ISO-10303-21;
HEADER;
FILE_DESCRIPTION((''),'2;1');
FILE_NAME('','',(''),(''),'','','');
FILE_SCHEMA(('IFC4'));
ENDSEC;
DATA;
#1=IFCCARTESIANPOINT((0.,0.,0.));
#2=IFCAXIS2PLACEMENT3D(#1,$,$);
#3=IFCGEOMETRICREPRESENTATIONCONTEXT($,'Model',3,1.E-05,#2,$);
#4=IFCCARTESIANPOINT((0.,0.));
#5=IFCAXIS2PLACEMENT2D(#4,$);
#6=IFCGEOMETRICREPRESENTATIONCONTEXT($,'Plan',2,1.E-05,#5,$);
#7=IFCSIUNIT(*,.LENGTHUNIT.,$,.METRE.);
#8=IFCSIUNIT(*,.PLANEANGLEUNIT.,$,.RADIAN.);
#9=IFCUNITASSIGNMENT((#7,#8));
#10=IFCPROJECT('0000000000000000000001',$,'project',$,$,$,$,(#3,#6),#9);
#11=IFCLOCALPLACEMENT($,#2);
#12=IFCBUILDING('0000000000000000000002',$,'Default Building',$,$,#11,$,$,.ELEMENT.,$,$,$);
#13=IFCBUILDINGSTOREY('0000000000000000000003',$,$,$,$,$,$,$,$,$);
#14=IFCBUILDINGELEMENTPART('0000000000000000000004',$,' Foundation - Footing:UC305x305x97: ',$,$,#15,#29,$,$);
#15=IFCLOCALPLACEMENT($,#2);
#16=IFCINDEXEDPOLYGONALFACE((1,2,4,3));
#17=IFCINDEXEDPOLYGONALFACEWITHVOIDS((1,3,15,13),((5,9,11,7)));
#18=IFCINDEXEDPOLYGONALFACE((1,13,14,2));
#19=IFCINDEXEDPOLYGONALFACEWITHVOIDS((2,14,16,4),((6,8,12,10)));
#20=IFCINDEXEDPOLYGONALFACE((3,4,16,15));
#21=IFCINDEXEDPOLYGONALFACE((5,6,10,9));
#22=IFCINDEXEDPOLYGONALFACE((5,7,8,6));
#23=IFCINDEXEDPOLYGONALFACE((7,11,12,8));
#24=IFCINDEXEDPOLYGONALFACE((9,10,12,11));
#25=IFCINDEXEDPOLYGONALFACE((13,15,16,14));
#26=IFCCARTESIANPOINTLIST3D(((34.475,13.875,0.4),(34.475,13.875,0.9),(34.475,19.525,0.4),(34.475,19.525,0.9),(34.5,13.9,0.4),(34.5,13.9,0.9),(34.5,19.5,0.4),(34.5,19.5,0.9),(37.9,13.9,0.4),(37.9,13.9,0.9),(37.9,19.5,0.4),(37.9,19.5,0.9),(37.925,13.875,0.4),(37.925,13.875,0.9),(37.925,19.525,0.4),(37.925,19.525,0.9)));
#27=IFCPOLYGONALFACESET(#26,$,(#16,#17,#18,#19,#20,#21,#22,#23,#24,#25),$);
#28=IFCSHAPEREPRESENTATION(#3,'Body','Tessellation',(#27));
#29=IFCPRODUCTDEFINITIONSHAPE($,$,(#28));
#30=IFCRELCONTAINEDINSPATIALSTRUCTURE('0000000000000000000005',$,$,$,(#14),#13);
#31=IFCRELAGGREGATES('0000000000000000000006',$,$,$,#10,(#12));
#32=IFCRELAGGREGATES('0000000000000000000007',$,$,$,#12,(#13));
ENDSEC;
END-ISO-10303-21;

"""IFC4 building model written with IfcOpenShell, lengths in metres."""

from ifc_helpers import new_model, si_unit, origin, origin_2d, place, context, project, spatial, polyline, outline, extrude, element, save


model = new_model("IFC4")

# Units and contexts
model_context = context("Model", 3, precision=1e-05, world=origin())
plan_context = context("Plan", 2, precision=1e-05, world=origin_2d())
ifc_project = project(units=[si_unit("LENGTHUNIT", "METRE"), si_unit("PLANEANGLEUNIT", "RADIAN")], contexts=[model_context, plan_context])

# Building, storey
building_placement = place(None, origin())
building = spatial("IfcBuilding", under=ifc_project, at=building_placement, Name="Default Building", CompositionType="ELEMENT")
storey = spatial("IfcBuildingStorey", under=building)

# Building element part, opening
building_element_part_1 = element("IfcBuildingElementPart", 1, inside=storey, Name=" Foundation - Footing:UC305x305x97: ", context=model_context, shape_type="SweptSolid", body=[
    extrude(outline(polyline([(37.925, 19.525, 0.4), (34.475, 19.525, 0.4), (34.475, 13.875, 0.4), (37.925, 13.875, 0.4), (37.925, 19.525, 0.4)])), None, (0.0, 0.0, 1.0), 0.5),
])
element("IfcOpeningElement", 2, inside=storey, cuts=building_element_part_1, context=model_context, shape_type="SweptSolid", body=[
    extrude(outline(polyline([(37.9, 19.5, 0.4), (34.5, 19.5, 0.4), (34.5, 13.9, 0.4), (37.9, 13.9, 0.4), (37.9, 19.5, 0.4)])), None, (0.0, 0.0, 1.0), 0.5),
])

save(model, "model.ifc")
